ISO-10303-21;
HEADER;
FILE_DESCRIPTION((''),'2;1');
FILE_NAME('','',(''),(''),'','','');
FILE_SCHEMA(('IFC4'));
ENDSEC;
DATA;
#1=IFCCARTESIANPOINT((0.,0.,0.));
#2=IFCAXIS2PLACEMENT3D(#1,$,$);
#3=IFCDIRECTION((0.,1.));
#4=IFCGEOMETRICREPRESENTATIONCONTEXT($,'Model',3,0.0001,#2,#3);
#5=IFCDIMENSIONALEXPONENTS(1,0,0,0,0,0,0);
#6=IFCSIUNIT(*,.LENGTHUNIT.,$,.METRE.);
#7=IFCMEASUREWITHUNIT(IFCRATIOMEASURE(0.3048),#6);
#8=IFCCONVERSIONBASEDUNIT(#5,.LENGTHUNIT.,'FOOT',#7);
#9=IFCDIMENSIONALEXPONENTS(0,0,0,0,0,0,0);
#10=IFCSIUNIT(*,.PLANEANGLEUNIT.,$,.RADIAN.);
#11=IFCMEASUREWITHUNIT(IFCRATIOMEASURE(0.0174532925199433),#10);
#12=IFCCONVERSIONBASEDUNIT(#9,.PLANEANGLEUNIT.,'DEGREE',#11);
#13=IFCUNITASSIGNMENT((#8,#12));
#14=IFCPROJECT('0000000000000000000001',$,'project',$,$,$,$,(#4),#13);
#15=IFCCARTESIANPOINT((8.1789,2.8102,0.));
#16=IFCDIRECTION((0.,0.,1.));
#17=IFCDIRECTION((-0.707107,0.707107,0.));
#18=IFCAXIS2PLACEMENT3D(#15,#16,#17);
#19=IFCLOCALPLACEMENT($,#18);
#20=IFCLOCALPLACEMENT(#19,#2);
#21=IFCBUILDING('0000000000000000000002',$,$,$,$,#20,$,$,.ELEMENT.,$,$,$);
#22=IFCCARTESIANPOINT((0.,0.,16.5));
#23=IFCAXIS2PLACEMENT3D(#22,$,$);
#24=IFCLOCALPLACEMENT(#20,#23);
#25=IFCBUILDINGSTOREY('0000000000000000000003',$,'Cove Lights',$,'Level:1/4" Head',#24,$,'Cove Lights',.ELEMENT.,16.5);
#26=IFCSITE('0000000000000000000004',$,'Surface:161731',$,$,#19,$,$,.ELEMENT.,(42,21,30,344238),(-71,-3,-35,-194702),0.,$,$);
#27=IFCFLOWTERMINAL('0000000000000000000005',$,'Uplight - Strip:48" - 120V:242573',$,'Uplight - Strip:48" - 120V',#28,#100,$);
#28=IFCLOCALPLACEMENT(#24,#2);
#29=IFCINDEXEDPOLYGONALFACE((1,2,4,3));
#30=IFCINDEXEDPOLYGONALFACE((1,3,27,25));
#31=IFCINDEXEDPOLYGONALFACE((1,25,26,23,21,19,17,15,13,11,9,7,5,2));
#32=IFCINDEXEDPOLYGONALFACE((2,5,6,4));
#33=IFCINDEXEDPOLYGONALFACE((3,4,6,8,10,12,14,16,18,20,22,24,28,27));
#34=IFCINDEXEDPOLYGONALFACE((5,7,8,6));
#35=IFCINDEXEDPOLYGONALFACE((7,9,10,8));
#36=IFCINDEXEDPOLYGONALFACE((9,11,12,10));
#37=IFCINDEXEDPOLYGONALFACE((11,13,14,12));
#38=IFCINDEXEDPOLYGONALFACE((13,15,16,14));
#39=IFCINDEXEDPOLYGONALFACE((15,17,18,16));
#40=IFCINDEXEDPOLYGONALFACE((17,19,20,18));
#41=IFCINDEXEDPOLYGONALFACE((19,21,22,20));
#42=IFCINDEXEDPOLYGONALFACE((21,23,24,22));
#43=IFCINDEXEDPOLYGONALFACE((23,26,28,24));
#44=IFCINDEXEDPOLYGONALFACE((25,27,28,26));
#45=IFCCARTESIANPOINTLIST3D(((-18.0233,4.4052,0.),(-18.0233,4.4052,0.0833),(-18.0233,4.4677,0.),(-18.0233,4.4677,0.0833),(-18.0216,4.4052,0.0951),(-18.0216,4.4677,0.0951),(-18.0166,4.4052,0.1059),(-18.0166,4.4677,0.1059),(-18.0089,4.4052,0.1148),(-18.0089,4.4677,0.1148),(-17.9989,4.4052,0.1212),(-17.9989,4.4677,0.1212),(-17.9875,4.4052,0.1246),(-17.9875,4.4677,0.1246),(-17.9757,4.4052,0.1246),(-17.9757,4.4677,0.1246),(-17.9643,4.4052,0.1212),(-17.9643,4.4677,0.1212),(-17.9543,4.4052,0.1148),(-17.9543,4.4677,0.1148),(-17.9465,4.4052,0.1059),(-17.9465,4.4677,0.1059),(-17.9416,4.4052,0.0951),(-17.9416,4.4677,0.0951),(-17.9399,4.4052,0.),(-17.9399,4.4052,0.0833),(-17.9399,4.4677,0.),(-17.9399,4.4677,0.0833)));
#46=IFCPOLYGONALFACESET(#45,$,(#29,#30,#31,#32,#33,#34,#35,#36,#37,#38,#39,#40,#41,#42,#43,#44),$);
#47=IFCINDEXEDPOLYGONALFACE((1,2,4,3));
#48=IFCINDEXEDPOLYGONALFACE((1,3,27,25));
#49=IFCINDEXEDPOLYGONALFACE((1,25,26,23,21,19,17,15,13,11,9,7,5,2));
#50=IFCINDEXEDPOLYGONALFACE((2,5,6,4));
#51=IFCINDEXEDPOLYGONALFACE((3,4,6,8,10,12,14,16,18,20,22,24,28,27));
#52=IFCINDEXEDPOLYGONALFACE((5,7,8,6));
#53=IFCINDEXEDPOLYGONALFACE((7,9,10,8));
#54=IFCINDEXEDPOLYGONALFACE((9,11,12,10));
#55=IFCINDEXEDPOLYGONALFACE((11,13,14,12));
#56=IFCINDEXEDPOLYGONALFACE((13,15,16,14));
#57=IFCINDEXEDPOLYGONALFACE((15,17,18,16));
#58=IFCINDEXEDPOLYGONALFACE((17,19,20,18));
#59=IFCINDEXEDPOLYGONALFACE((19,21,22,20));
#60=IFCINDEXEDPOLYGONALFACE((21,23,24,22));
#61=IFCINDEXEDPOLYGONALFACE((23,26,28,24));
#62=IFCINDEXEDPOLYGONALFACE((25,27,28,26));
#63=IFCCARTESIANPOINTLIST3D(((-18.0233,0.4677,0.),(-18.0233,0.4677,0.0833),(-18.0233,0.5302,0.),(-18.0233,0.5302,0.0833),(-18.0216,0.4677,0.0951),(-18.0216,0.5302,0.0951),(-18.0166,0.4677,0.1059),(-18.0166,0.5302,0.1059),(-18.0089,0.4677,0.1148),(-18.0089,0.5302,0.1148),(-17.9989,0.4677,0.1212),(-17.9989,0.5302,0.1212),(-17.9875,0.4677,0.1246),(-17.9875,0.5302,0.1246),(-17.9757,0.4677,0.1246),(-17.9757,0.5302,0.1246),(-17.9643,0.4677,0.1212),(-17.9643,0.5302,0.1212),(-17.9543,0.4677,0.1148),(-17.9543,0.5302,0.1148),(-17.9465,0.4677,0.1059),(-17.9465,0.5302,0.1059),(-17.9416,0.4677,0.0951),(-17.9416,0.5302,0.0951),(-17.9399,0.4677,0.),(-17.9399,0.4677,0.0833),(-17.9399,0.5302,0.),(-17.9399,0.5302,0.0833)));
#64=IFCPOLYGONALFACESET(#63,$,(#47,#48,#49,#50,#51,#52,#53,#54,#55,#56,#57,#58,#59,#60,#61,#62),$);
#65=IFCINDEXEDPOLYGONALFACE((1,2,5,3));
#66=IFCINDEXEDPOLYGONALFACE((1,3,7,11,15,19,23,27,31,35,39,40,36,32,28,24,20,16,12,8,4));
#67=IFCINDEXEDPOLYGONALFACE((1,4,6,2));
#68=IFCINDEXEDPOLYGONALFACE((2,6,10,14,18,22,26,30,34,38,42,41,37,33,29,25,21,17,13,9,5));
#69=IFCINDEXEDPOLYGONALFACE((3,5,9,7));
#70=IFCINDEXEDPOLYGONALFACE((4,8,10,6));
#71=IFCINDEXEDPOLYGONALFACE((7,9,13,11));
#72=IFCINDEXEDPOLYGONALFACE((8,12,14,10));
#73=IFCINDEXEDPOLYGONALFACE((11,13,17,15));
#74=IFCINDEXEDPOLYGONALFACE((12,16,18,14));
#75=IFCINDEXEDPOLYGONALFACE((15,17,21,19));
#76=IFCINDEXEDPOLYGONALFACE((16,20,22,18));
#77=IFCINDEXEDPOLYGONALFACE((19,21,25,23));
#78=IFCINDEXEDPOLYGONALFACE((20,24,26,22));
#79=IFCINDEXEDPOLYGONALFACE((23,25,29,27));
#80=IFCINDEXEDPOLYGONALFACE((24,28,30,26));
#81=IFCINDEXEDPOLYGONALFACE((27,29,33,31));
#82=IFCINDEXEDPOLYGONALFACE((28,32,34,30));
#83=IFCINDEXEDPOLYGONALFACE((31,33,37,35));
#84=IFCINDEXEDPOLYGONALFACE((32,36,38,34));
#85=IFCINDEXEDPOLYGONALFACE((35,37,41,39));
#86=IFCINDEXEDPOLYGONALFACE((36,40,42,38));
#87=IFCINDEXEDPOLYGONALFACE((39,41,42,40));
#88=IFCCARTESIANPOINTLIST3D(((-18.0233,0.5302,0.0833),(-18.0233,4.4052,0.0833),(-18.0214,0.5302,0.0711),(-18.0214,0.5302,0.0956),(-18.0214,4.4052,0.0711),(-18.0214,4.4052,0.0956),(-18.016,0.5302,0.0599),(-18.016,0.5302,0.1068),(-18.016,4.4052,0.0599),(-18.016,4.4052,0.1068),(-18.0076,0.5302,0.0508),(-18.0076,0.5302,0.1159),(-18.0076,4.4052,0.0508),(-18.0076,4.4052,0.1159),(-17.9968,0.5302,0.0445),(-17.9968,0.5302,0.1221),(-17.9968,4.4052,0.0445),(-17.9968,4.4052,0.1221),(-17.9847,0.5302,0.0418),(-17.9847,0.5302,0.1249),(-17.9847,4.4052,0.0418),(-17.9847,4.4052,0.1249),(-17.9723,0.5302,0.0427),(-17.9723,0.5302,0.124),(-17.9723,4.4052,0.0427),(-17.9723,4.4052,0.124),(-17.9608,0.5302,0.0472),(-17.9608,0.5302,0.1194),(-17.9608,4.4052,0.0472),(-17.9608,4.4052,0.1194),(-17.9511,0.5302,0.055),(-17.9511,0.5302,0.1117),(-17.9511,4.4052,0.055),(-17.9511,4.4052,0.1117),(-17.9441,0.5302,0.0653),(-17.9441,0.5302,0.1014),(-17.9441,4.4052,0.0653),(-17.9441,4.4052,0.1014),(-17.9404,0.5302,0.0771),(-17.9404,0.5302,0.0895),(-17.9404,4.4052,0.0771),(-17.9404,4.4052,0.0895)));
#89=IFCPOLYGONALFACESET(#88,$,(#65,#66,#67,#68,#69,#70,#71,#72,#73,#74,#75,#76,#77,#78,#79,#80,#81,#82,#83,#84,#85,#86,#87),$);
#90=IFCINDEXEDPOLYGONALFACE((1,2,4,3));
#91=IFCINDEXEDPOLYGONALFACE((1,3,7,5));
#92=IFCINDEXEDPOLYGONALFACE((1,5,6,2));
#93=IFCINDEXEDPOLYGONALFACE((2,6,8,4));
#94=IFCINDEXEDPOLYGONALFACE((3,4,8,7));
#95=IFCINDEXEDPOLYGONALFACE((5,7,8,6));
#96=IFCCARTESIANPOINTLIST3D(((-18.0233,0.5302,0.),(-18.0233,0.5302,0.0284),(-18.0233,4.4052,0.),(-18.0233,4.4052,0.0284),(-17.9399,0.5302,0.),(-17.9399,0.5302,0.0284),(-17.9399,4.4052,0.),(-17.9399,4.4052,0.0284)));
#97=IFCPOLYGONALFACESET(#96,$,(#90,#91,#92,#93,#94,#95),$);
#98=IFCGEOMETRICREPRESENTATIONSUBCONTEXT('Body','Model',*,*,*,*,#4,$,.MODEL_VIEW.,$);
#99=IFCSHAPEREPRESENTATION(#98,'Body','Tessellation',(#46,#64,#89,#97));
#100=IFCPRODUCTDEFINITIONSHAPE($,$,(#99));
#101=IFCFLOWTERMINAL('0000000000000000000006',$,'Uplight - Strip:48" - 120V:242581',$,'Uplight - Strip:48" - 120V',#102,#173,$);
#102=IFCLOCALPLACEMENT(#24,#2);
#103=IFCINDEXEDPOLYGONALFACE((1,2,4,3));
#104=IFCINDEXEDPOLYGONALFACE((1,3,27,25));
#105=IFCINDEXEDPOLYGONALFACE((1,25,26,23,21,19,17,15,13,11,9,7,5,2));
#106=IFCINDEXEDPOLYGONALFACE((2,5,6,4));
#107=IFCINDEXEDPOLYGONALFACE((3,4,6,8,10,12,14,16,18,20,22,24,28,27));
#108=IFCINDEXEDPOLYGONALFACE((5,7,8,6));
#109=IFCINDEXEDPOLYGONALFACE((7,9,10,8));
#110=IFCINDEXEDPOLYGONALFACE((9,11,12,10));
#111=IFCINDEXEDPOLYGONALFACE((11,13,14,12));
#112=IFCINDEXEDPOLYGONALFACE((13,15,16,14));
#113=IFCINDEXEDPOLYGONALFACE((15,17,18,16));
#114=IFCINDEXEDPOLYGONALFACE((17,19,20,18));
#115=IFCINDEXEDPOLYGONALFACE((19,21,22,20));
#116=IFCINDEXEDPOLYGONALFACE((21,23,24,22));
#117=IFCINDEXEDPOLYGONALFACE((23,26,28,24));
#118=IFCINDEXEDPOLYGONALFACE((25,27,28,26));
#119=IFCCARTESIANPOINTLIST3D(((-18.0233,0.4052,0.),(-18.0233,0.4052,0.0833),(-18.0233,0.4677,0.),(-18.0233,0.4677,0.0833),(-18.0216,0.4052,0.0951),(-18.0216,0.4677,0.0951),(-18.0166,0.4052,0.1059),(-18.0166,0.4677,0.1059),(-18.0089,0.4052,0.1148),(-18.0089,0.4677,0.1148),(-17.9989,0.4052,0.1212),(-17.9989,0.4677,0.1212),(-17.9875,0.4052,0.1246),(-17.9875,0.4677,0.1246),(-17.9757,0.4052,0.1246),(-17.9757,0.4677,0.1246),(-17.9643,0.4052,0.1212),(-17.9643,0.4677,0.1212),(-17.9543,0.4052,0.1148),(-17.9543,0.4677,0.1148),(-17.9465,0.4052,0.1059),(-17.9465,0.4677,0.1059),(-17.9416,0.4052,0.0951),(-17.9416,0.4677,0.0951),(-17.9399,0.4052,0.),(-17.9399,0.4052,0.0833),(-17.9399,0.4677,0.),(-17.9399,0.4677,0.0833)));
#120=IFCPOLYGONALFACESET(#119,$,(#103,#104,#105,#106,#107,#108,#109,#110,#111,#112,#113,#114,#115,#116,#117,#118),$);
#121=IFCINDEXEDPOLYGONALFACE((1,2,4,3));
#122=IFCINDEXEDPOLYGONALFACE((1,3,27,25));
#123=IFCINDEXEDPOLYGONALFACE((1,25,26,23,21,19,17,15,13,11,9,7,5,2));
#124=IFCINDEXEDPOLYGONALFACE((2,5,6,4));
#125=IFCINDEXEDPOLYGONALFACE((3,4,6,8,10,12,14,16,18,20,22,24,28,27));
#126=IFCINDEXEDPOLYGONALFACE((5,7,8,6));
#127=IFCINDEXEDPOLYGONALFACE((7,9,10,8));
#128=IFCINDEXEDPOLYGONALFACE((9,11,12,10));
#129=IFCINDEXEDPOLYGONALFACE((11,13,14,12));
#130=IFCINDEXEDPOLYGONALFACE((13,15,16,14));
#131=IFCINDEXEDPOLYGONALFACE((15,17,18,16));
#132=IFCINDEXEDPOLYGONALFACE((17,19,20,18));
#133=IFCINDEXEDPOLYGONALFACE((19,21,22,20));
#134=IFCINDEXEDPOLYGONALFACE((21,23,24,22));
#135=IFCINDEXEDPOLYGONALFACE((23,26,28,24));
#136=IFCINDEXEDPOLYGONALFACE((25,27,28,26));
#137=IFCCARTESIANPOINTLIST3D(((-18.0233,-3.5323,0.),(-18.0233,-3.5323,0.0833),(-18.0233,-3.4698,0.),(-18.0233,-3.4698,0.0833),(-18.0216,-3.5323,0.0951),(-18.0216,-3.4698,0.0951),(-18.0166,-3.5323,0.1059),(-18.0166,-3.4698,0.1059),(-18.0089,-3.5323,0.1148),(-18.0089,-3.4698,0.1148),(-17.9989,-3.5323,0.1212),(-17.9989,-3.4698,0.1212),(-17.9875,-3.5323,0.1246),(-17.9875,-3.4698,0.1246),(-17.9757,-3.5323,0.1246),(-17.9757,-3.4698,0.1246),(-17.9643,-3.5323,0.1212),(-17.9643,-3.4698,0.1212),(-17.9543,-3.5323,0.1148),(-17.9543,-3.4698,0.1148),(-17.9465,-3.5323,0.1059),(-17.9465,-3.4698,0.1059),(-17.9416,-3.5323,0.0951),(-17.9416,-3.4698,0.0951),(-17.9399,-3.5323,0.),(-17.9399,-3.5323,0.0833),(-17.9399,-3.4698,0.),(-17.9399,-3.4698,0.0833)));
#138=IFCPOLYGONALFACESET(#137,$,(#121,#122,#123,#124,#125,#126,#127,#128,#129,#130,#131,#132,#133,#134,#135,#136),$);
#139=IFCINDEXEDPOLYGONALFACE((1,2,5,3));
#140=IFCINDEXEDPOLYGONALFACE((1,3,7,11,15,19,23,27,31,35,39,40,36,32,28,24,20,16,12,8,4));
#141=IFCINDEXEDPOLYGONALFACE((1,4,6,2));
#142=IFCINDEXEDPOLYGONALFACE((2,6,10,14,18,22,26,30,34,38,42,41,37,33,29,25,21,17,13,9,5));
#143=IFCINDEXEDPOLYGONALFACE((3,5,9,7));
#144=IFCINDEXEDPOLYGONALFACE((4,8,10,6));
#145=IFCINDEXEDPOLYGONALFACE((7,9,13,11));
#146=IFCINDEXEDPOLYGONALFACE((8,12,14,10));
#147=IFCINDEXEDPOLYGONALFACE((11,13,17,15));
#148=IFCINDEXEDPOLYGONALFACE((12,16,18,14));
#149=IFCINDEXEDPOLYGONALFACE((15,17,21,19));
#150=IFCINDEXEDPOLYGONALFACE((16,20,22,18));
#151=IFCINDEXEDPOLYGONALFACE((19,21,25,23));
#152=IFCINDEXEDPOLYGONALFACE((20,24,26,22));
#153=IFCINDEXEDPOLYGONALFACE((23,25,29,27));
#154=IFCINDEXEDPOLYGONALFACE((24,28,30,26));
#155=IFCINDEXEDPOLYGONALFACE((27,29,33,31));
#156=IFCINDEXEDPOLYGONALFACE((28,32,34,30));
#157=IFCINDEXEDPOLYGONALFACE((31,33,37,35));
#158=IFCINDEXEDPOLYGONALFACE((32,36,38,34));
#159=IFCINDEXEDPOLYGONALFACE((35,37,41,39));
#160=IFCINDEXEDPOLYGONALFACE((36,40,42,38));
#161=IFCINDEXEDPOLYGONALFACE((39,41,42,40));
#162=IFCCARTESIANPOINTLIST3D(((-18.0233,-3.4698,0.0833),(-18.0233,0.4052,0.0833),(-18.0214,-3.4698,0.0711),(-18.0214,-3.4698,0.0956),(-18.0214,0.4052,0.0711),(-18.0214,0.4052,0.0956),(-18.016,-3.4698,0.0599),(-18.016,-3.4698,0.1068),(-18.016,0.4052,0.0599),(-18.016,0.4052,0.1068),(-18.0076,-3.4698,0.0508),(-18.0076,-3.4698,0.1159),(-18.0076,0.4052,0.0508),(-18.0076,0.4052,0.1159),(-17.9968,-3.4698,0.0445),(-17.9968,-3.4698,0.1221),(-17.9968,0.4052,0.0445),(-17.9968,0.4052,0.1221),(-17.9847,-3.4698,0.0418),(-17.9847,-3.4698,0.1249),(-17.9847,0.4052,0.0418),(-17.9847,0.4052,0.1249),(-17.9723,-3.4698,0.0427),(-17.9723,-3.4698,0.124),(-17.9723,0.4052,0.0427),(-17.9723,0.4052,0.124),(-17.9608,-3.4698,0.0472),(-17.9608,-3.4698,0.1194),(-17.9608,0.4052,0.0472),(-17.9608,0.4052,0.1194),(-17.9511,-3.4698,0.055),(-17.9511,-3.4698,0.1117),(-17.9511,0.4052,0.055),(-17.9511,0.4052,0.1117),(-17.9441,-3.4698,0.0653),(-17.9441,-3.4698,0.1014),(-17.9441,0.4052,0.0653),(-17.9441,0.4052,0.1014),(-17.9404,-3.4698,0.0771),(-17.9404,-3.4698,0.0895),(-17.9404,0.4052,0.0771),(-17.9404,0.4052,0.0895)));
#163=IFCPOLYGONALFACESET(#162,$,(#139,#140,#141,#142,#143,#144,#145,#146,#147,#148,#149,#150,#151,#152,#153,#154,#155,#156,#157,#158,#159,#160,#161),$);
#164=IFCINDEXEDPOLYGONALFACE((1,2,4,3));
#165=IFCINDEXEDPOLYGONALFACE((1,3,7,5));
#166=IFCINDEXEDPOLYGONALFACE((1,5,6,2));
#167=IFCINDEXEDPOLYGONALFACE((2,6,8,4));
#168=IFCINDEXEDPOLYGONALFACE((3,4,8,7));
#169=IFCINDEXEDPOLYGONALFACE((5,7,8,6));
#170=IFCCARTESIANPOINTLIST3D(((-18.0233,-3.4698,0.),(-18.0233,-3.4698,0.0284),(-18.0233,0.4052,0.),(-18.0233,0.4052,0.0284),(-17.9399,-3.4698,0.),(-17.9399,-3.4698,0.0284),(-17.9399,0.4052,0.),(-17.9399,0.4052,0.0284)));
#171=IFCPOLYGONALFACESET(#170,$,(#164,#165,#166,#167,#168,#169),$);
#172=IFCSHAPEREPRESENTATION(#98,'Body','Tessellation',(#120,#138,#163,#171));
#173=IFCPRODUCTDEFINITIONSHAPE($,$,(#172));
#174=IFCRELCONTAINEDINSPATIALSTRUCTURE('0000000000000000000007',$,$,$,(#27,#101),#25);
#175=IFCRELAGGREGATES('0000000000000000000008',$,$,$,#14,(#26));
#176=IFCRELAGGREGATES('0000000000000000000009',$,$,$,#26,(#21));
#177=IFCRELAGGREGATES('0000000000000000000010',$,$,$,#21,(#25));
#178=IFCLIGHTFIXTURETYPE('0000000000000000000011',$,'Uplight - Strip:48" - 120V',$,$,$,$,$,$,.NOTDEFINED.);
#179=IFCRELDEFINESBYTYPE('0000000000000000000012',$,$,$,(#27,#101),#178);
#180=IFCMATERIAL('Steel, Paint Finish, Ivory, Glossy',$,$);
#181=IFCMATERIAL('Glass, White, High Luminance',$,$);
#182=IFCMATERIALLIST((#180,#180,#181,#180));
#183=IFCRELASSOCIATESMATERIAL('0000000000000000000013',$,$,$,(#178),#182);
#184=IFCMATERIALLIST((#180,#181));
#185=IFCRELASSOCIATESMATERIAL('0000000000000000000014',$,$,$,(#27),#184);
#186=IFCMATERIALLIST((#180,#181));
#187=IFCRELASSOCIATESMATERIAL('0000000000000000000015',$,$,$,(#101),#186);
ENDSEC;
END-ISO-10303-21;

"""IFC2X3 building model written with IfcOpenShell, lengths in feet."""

from ifc_helpers import new_model, entity, si_unit, converted_unit, direction, frame, frame_2d, origin, origin_2d_with_axis, place, context, subcontext, project, spatial, polyline, circle_curve, parameter, trimmed, segment, composite_curve, rectangle, circle, outline, extrude, source, transform, mapped, material, material_list, type_object, type_shapes, element, save


model = new_model("IFC2X3")

# Units and contexts
model_context = context("Model", 3, precision=0.0001, world=origin(), true_north=direction((0.0, 1.0)))
body_context = subcontext(model_context, "Body", "Model", "MODEL_VIEW")
ifc_project = project(units=[converted_unit("LENGTHUNIT", "FOOT", entity("IfcRatioMeasure", 0.3048), si_unit("LENGTHUNIT", "METRE"), dimensions=[1, 0, 0, 0, 0, 0, 0]), converted_unit("PLANEANGLEUNIT", "DEGREE", entity("IfcRatioMeasure", 0.0174532925199433), si_unit("PLANEANGLEUNIT", "RADIAN"), dimensions=[0, 0, 0, 0, 0, 0, 0])], contexts=[model_context])

# Site, building, storey
site_placement = place(None, frame((8.1789, 2.8102, 0.0), z_axis=(0.0, 0.0, 1.0), x_axis=(-0.707107, 0.707107, 0.0)))
site = spatial("IfcSite", under=ifc_project, at=site_placement, Name="Surface:161731", CompositionType="ELEMENT", RefLatitude=(42, 21, 30, 344238), RefLongitude=(-71, -3, -35, -194702), RefElevation=0.0)
building_placement = place(site_placement, origin())
building = spatial("IfcBuilding", under=site, at=building_placement, CompositionType="ELEMENT")
storey_placement = place(building_placement, frame((0.0, 0.0, 16.5)))
storey = spatial("IfcBuildingStorey", under=building, at=storey_placement, Name="Cove Lights", ObjectType="Level:1/4\" Head", LongName="Cove Lights", CompositionType="ELEMENT", Elevation=16.5)

# Flow terminals
ifc_material_1 = material(Name="Steel, Paint Finish, Ivory, Glossy")
ifc_material_2 = material(Name="Glass, White, High Luminance")
ifc_material_list_1 = material_list([ifc_material_1, ifc_material_1, ifc_material_2, ifc_material_1])
light_fixture_type_1 = type_object("IfcLightFixtureType", Name="Uplight - Strip:48\" - 120V", PredefinedType="NOTDEFINED", material=ifc_material_list_1)
shared_shape_1 = source(origin(), body_context, "Body", "SweptSolid", [
    extrude(outline(composite_curve([segment(polyline([(-0.0417, -0.0417), (0.0417, -0.0417)]), True, "CONTINUOUS"), segment(trimmed(circle_curve(frame_2d((0.0417, 0.0), x_axis=(0.0, -1.0)), 0.0417), [parameter(0.0)], [parameter(180.0)], True, "PARAMETER"), True, "CONTINUOUS"), segment(polyline([(0.0417, 0.0417), (-0.0417, 0.0417)]), True, "CONTINUOUS"), segment(polyline([(-0.0417, 0.0417), (-0.0417, -0.0417)]), True, "CONTINUOUS")], self_intersect=False)), frame((1.9375, 0.0, 0.0417), z_axis=(1.0, 0.0, 0.0), x_axis=(0.0, 0.0, 1.0)), (0.0, 0.0, 1.0), 0.0625),
    extrude(outline(composite_curve([segment(polyline([(-0.0417, -0.0417), (0.0417, -0.0417)]), True, "CONTINUOUS"), segment(polyline([(0.0417, -0.0417), (0.0417, 0.0417)]), True, "CONTINUOUS"), segment(trimmed(circle_curve(frame_2d((0.0, 0.0417), x_axis=(0.0, 1.0)), 0.0417), [parameter(270.0)], [parameter(90.0)], True, "PARAMETER"), True, "CONTINUOUS"), segment(polyline([(-0.0417, 0.0417), (-0.0417, -0.0417)]), True, "CONTINUOUS")], self_intersect=False)), frame((-2.0, 0.0, 0.0417), z_axis=(1.0, 0.0, 0.0), x_axis=(0.0, 1.0, 0.0)), (0.0, 0.0, 1.0), 0.0625),
    extrude(circle(Radius=0.0417, at=frame_2d((0.0, 0.0), x_axis=(1.0, 0.0))), frame((-1.9375, 0.0, 0.0833), z_axis=(1.0, 0.0, 0.0), x_axis=(0.0, 1.0, 0.0)), (0.0, 0.0, 1.0), 3.875),
    extrude(rectangle(XDim=3.875, YDim=0.0833, at=origin_2d_with_axis()), frame((0.0, 0.0, 0.0), z_axis=(0.0, 0.0, 1.0), x_axis=(-1.0, 0.0, 0.0)), (0.0, 0.0, 1.0), 0.0284),
])
type_shapes(light_fixture_type_1, [shared_shape_1])
ifc_material_list_2 = material_list([ifc_material_1, ifc_material_2])
flow_terminal_1_placement = place(storey_placement, frame((-17.9816, 2.4677, 0.0), z_axis=(0.0, 0.0, 1.0), x_axis=(0.0, 1.0, 0.0)))
element("IfcFlowTerminal", 1, at=flow_terminal_1_placement, inside=storey, type_object=light_fixture_type_1, material=ifc_material_list_2, Name="Uplight - Strip:48\" - 120V:242573", ObjectType="Uplight - Strip:48\" - 120V", context=body_context, shape_type="MappedRepresentation", body=[
    mapped(shared_shape_1, transform((0.0, 0.0, 0.0), scale=1.0)),
])
ifc_material_list_3 = material_list([ifc_material_1, ifc_material_2])
flow_terminal_2_placement = place(storey_placement, frame((-17.9816, -1.5323, 0.0), z_axis=(0.0, 0.0, 1.0), x_axis=(0.0, 1.0, 0.0)))
element("IfcFlowTerminal", 2, at=flow_terminal_2_placement, inside=storey, type_object=light_fixture_type_1, material=ifc_material_list_3, Name="Uplight - Strip:48\" - 120V:242581", ObjectType="Uplight - Strip:48\" - 120V", context=body_context, shape_type="MappedRepresentation", body=[
    mapped(shared_shape_1, transform((0.0, 0.0, 0.0), scale=1.0)),
])

save(model, "model.ifc")
